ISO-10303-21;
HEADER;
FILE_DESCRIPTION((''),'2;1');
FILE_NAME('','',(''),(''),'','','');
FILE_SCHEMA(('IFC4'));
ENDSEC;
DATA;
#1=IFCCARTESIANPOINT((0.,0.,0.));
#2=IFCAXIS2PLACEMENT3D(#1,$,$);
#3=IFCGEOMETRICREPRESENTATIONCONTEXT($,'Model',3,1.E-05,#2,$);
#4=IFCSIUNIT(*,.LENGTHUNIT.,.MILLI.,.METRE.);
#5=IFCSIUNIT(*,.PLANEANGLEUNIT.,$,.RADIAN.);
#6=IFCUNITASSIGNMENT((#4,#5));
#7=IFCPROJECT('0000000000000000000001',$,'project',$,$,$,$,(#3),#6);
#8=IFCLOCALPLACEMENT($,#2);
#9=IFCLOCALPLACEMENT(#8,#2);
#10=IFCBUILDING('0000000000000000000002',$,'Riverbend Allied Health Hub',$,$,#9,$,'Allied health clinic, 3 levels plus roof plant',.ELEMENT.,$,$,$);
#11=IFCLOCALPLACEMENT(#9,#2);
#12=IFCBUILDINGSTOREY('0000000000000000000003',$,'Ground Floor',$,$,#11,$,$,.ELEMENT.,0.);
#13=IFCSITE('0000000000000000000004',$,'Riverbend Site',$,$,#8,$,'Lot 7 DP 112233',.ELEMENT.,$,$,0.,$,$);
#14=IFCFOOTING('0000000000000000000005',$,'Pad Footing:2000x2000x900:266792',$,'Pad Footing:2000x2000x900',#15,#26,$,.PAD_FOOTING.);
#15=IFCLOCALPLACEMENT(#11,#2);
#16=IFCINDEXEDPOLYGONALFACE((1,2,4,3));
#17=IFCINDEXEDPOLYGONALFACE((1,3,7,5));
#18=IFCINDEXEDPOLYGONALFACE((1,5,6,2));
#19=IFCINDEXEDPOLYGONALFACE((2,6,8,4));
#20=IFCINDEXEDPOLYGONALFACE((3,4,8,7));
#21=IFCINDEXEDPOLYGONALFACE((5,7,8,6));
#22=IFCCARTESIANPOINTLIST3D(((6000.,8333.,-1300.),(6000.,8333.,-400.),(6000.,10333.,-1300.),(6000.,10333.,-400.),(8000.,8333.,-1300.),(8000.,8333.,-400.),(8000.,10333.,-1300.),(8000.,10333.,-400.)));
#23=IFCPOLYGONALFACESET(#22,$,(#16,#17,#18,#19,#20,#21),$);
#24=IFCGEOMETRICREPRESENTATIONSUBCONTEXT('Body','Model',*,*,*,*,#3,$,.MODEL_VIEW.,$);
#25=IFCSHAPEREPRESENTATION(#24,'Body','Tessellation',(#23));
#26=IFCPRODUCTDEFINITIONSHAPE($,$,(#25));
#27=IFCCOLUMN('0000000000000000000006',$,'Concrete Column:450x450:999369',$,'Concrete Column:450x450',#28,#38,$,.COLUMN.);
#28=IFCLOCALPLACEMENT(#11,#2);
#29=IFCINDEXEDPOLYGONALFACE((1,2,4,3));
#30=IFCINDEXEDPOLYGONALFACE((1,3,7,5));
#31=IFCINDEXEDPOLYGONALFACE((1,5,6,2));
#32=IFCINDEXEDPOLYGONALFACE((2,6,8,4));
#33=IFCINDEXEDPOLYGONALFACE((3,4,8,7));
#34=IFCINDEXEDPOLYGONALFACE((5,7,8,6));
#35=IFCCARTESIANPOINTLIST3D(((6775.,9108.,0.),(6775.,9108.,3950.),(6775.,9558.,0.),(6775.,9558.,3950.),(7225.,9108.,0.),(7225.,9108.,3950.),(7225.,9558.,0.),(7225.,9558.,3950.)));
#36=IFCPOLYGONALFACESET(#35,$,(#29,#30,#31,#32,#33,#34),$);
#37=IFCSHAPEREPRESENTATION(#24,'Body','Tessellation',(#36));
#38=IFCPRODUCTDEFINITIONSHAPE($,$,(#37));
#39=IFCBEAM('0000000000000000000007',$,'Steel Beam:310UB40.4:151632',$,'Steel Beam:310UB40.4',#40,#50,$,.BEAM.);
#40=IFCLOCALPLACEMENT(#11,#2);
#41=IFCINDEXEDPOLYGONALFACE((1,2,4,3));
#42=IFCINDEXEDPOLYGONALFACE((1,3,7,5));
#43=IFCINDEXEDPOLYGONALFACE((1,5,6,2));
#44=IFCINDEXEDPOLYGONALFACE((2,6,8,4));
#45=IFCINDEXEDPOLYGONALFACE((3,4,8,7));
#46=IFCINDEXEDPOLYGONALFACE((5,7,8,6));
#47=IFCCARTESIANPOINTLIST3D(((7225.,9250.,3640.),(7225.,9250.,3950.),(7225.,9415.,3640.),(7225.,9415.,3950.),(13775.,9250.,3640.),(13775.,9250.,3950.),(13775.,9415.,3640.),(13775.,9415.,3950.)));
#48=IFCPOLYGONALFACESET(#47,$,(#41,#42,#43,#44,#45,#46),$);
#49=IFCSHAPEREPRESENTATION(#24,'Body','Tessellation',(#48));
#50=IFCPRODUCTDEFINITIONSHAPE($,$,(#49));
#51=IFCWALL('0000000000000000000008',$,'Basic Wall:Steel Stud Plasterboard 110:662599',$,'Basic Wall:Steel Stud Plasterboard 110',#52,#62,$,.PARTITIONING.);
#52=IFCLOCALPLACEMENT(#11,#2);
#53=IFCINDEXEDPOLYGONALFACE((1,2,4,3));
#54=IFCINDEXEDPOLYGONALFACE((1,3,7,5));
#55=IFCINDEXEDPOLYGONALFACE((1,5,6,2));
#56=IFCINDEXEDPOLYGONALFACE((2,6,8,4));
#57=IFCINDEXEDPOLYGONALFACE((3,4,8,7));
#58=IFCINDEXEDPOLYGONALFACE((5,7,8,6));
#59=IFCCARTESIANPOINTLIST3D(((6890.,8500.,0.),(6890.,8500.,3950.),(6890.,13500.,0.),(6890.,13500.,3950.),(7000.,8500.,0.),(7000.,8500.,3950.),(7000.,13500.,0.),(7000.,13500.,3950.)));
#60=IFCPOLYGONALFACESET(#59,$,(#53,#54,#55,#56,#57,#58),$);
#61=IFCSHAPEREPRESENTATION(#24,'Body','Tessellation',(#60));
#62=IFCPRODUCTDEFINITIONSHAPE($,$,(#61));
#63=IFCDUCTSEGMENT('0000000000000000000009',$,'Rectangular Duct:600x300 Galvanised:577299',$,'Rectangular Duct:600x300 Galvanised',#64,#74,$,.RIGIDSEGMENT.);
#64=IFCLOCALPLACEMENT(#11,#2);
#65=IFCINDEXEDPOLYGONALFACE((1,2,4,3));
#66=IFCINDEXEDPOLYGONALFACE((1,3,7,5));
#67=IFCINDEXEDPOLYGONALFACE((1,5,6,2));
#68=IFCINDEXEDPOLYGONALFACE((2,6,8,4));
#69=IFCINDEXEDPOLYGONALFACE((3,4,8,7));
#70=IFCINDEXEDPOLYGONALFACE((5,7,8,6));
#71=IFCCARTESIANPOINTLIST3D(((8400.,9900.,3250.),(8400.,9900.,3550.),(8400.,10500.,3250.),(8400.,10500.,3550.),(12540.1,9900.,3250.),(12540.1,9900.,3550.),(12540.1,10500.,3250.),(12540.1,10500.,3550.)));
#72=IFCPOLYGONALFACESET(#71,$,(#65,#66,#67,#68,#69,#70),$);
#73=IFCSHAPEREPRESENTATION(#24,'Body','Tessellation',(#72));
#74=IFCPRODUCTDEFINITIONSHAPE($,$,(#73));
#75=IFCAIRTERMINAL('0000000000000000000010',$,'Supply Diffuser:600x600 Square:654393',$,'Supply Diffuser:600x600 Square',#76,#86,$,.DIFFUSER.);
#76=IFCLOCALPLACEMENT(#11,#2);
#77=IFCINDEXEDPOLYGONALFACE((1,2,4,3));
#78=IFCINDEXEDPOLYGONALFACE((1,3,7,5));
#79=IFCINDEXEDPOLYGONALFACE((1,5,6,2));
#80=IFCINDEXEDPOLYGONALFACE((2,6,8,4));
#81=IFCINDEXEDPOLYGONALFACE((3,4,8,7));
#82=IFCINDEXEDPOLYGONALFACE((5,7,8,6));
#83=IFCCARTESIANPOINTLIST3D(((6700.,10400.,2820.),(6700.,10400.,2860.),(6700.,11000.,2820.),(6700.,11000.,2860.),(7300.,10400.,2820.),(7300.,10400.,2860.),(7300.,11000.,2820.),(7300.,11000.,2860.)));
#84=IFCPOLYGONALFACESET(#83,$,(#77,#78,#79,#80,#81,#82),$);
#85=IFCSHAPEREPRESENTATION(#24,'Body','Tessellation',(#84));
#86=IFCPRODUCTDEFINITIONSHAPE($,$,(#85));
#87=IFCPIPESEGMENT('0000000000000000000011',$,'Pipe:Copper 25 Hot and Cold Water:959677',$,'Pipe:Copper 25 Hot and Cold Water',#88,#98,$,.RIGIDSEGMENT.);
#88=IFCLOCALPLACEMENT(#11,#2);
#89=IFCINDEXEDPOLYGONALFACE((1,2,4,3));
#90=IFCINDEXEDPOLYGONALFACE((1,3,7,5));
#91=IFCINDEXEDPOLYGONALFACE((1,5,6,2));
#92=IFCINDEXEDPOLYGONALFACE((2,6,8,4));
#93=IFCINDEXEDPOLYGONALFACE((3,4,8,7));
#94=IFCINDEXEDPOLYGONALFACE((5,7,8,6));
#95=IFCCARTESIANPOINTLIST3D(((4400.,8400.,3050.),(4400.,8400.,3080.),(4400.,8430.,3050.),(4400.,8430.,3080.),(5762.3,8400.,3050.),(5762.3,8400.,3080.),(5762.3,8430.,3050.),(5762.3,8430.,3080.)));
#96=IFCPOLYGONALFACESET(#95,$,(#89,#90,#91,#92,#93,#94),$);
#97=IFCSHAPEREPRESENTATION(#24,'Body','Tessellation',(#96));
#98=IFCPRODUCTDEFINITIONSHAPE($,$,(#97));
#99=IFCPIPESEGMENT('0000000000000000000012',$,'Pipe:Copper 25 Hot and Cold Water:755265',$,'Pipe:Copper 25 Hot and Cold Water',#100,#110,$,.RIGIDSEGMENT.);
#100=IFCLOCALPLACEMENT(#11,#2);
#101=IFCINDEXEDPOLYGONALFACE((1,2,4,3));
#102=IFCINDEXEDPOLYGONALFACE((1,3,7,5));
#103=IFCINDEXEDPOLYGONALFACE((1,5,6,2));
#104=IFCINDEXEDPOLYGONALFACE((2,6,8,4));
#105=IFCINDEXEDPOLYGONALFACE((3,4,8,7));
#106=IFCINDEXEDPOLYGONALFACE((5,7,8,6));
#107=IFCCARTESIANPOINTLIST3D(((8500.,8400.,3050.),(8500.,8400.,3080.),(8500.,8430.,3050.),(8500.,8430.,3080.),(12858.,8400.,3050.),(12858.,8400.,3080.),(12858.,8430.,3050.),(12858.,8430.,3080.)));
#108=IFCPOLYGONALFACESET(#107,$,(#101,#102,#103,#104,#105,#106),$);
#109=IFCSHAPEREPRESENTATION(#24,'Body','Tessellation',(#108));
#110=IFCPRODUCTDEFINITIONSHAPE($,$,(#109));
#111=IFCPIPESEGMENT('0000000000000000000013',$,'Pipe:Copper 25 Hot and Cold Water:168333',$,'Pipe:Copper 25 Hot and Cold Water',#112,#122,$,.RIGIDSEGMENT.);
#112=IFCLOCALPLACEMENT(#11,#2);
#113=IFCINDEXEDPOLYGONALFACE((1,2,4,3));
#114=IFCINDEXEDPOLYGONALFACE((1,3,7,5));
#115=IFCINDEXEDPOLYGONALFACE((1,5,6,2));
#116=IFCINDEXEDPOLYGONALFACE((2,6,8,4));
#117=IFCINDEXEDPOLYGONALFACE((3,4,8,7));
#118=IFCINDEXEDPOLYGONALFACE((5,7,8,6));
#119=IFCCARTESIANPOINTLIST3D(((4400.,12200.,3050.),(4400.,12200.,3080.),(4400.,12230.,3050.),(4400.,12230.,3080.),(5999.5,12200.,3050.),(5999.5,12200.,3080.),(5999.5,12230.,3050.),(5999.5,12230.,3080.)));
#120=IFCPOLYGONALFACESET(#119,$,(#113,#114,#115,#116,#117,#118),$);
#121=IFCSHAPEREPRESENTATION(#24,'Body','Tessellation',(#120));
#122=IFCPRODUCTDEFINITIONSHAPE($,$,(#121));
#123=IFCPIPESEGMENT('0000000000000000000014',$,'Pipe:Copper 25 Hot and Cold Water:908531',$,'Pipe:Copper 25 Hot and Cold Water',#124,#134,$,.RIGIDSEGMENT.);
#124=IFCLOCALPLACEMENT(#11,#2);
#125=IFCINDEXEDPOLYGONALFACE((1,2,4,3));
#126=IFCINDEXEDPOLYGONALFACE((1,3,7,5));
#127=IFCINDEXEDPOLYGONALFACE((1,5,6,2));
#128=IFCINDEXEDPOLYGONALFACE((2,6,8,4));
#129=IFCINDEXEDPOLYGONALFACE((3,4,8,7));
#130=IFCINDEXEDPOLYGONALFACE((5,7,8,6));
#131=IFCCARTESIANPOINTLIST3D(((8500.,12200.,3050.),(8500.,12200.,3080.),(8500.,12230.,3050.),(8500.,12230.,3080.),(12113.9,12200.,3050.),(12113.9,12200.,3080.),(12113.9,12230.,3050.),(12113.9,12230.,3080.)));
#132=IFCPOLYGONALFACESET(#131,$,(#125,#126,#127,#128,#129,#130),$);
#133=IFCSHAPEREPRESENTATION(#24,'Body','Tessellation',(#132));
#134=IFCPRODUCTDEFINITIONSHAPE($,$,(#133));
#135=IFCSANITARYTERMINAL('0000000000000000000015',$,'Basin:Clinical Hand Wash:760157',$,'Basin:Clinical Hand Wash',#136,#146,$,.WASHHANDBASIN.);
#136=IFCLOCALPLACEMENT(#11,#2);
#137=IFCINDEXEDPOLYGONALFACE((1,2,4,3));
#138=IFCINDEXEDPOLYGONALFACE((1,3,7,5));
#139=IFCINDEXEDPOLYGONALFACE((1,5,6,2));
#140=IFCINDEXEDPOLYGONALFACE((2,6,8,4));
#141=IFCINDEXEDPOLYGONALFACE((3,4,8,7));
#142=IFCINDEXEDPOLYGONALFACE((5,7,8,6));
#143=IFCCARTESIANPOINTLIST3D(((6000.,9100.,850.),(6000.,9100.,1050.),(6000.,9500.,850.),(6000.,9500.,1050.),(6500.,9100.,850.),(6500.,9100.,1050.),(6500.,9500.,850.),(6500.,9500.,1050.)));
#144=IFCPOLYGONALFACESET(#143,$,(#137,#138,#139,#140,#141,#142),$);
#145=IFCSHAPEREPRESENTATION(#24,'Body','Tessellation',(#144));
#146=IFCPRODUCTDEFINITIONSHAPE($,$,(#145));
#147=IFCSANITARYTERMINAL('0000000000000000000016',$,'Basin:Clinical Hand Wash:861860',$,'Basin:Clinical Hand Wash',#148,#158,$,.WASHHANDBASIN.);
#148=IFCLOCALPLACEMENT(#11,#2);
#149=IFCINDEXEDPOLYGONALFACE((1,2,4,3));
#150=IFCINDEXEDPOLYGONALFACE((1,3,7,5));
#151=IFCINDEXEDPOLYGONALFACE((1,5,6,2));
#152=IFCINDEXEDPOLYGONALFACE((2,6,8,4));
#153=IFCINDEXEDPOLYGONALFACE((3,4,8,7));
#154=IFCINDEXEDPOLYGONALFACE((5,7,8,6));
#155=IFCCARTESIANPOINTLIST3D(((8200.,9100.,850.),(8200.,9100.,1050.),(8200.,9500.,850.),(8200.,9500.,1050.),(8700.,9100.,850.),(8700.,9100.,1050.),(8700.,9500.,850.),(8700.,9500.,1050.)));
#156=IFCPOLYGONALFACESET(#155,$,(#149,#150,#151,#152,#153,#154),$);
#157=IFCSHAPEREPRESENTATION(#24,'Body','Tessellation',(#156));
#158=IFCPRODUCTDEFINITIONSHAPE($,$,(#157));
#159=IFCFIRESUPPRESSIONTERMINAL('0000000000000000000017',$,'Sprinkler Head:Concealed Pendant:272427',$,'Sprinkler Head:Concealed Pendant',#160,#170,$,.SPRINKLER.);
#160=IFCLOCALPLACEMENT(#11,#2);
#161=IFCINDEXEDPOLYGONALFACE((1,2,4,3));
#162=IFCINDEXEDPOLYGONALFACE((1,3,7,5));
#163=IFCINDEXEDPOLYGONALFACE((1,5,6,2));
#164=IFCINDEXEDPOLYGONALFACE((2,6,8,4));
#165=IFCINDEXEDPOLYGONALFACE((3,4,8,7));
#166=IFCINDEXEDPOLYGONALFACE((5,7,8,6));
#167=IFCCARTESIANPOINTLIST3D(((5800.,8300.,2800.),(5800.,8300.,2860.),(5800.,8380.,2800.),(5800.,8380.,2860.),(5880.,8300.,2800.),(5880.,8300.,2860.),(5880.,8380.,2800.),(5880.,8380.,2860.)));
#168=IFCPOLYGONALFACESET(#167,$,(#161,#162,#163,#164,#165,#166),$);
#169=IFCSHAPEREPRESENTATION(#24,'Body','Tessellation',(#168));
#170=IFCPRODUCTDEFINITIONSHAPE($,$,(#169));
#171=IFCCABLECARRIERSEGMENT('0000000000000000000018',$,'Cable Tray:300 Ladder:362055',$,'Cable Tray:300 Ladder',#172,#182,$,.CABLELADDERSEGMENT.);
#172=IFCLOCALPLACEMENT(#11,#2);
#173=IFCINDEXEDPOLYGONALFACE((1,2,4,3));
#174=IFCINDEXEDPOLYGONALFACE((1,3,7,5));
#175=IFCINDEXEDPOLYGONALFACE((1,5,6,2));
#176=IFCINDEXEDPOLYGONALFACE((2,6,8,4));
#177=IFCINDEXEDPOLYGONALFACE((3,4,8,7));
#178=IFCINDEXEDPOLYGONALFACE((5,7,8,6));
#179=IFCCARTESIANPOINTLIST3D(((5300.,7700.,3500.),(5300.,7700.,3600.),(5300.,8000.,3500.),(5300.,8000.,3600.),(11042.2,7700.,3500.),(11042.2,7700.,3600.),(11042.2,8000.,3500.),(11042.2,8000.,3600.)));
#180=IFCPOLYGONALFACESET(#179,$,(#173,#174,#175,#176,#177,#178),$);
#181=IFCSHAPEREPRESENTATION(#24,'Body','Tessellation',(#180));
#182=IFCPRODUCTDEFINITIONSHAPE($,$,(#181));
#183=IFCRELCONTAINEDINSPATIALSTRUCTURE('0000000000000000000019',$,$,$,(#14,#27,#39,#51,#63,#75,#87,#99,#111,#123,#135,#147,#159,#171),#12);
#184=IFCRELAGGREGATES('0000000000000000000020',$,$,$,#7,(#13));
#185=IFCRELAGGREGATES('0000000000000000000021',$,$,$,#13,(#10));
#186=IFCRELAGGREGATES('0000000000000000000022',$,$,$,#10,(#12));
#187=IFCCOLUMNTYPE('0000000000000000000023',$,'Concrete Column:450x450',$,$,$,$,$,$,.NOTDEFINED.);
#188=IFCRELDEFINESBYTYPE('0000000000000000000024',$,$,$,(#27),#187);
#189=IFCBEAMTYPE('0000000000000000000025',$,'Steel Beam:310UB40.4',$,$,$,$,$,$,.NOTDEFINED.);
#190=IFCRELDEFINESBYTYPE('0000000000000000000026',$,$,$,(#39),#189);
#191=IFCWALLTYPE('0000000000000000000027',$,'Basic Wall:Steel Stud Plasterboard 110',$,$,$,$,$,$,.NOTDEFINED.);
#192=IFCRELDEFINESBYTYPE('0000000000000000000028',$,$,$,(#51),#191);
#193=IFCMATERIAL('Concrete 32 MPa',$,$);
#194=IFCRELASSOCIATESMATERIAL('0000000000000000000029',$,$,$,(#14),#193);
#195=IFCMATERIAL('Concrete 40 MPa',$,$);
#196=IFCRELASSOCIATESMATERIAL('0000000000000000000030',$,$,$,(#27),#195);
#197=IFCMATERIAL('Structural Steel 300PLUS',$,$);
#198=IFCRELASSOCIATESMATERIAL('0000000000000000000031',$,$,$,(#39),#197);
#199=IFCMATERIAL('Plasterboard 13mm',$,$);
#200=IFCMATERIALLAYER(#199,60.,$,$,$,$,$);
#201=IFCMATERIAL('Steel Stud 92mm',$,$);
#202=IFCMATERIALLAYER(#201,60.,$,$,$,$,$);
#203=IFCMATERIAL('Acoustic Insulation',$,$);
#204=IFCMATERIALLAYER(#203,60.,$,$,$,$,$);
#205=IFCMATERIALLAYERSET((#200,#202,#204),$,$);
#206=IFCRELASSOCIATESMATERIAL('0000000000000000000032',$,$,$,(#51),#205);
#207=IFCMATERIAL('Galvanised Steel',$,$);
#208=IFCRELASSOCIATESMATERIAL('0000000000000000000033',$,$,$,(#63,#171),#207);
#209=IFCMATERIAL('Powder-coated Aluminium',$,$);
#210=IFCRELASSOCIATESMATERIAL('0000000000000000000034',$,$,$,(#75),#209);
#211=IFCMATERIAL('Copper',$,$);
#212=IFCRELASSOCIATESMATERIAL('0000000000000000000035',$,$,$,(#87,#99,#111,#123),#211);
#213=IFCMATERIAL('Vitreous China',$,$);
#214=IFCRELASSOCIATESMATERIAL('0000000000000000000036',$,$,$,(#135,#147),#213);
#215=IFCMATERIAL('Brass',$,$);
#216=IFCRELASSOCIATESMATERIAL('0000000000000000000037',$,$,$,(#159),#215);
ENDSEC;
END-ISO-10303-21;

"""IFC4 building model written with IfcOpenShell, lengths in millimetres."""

from ifc_helpers import new_model, si_unit, frame, frame_2d, origin, place, context, subcontext, project, spatial, rectangle, extrude, material, layer, layer_set, layer_usage, type_object, element, save


model = new_model("IFC4")

# Units and contexts
model_context = context("Model", 3, precision=1e-05, world=origin())
body_context = subcontext(model_context, "Body", "Model", "MODEL_VIEW")
ifc_project = project(units=[si_unit("LENGTHUNIT", "METRE", prefix="MILLI"), si_unit("PLANEANGLEUNIT", "RADIAN")], contexts=[model_context])

# Site, building, storey
site_placement = place(None, origin())
site = spatial("IfcSite", under=ifc_project, at=site_placement, Name="Riverbend Site", LongName="Lot 7 DP 112233", CompositionType="ELEMENT", RefElevation=0.0)
building_placement = place(site_placement, origin())
building = spatial("IfcBuilding", under=site, at=building_placement, Name="Riverbend Allied Health Hub", LongName="Allied health clinic, 3 levels plus roof plant", CompositionType="ELEMENT")
storey_placement = place(building_placement, origin())
storey = spatial("IfcBuildingStorey", under=building, at=storey_placement, Name="Ground Floor", CompositionType="ELEMENT", Elevation=0.0)

# Footing
ifc_material_1 = material(Name="Concrete 32 MPa")
footing_placement = place(storey_placement, frame((6000.0, 8333.0, -1300.0)))
element("IfcFooting", 1, at=footing_placement, inside=storey, material=ifc_material_1, Name="Pad Footing:2000x2000x900:266792", ObjectType="Pad Footing:2000x2000x900", PredefinedType="PAD_FOOTING", context=body_context, shape_type="SweptSolid", body=[
    extrude(rectangle(XDim=2000.0, YDim=2000.0, at=frame_2d((1000.0, 1000.0))), origin(), (0.0, 0.0, 1.0), 900.0),
])

# Column
ifc_material_2 = material(Name="Concrete 40 MPa")
column_type = type_object("IfcColumnType", Name="Concrete Column:450x450", PredefinedType="NOTDEFINED")
column_placement = place(storey_placement, frame((6775.0, 9108.0, 0.0)))
element("IfcColumn", 2, at=column_placement, inside=storey, type_object=column_type, material=ifc_material_2, Name="Concrete Column:450x450:999369", ObjectType="Concrete Column:450x450", PredefinedType="COLUMN", context=body_context, shape_type="SweptSolid", body=[
    extrude(rectangle(XDim=450.0, YDim=450.0, at=frame_2d((225.0, 225.0))), origin(), (0.0, 0.0, 1.0), 3950.0),
])

# Beam
ifc_material_3 = material(Name="Structural Steel 300PLUS")
beam_type = type_object("IfcBeamType", Name="Steel Beam:310UB40.4", PredefinedType="NOTDEFINED")
beam_placement = place(storey_placement, frame((7225.0, 9250.0, 3640.0)))
element("IfcBeam", 3, at=beam_placement, inside=storey, type_object=beam_type, material=ifc_material_3, Name="Steel Beam:310UB40.4:151632", ObjectType="Steel Beam:310UB40.4", PredefinedType="BEAM", context=body_context, shape_type="SweptSolid", body=[
    extrude(rectangle(XDim=6550.0, YDim=165.0, at=frame_2d((3275.0, 82.5))), origin(), (0.0, 0.0, 1.0), 310.0),
])

# Wall
ifc_material_4 = material(Name="Plasterboard 13mm")
ifc_layer_1 = layer(ifc_material_4, 60.0)
ifc_material_5 = material(Name="Steel Stud 92mm")
ifc_layer_2 = layer(ifc_material_5, 60.0)
ifc_material_6 = material(Name="Acoustic Insulation")
ifc_layer_3 = layer(ifc_material_6, 60.0)
ifc_layer_set = layer_set([ifc_layer_1, ifc_layer_2, ifc_layer_3])
ifc_layer_usage = layer_usage(ifc_layer_set, "AXIS2", "POSITIVE", 0.0)
wall_type = type_object("IfcWallType", Name="Basic Wall:Steel Stud Plasterboard 110", PredefinedType="NOTDEFINED")
wall_placement = place(storey_placement, frame((7000.0, 8500.0, 0.0), z_axis=(0.0, 0.0, 1.0), x_axis=(0.0, 1.0, 0.0)))
element("IfcWall", 4, at=wall_placement, inside=storey, type_object=wall_type, material=ifc_layer_usage, Name="Basic Wall:Steel Stud Plasterboard 110:662599", ObjectType="Basic Wall:Steel Stud Plasterboard 110", PredefinedType="PARTITIONING", context=body_context, shape_type="SweptSolid", body=[
    extrude(rectangle(XDim=5000.0, YDim=110.0, at=frame_2d((2500.0, 55.0))), origin(), (0.0, 0.0, 1.0), 3950.0),
])

# Duct segment
ifc_material_7 = material(Name="Galvanised Steel")
duct_segment_placement = place(storey_placement, frame((8400.0, 9900.0, 3250.0)))
element("IfcDuctSegment", 5, at=duct_segment_placement, inside=storey, material=ifc_material_7, Name="Rectangular Duct:600x300 Galvanised:577299", ObjectType="Rectangular Duct:600x300 Galvanised", PredefinedType="RIGIDSEGMENT", context=body_context, shape_type="SweptSolid", body=[
    extrude(rectangle(XDim=4140.1, YDim=600.0, at=frame_2d((2070.0, 300.0))), origin(), (0.0, 0.0, 1.0), 300.0),
])

# Air terminal
ifc_material_8 = material(Name="Powder-coated Aluminium")
air_terminal_placement = place(storey_placement, frame((6700.0, 10400.0, 2820.0)))
element("IfcAirTerminal", 6, at=air_terminal_placement, inside=storey, material=ifc_material_8, Name="Supply Diffuser:600x600 Square:654393", ObjectType="Supply Diffuser:600x600 Square", PredefinedType="DIFFUSER", context=body_context, shape_type="SweptSolid", body=[
    extrude(rectangle(XDim=600.0, YDim=600.0, at=frame_2d((300.0, 300.0))), origin(), (0.0, 0.0, 1.0), 40.0),
])

# Pipe segments
ifc_material_9 = material(Name="Copper")
pipe_segment_1_placement = place(storey_placement, frame((4400.0, 8400.0, 3050.0)))
element("IfcPipeSegment", 7, at=pipe_segment_1_placement, inside=storey, material=ifc_material_9, Name="Pipe:Copper 25 Hot and Cold Water:959677", ObjectType="Pipe:Copper 25 Hot and Cold Water", PredefinedType="RIGIDSEGMENT", context=body_context, shape_type="SweptSolid", body=[
    extrude(rectangle(XDim=1362.3, YDim=30.0, at=frame_2d((681.2, 15.0))), origin(), (0.0, 0.0, 1.0), 30.0),
])
pipe_segment_2_placement = place(storey_placement, frame((8500.0, 8400.0, 3050.0)))
element("IfcPipeSegment", 8, at=pipe_segment_2_placement, inside=storey, material=ifc_material_9, Name="Pipe:Copper 25 Hot and Cold Water:755265", ObjectType="Pipe:Copper 25 Hot and Cold Water", PredefinedType="RIGIDSEGMENT", context=body_context, shape_type="SweptSolid", body=[
    extrude(rectangle(XDim=4358.0, YDim=30.0, at=frame_2d((2179.0, 15.0))), origin(), (0.0, 0.0, 1.0), 30.0),
])
pipe_segment_3_placement = place(storey_placement, frame((4400.0, 12200.0, 3050.0)))
element("IfcPipeSegment", 9, at=pipe_segment_3_placement, inside=storey, material=ifc_material_9, Name="Pipe:Copper 25 Hot and Cold Water:168333", ObjectType="Pipe:Copper 25 Hot and Cold Water", PredefinedType="RIGIDSEGMENT", context=body_context, shape_type="SweptSolid", body=[
    extrude(rectangle(XDim=1599.5, YDim=30.0, at=frame_2d((799.8, 15.0))), origin(), (0.0, 0.0, 1.0), 30.0),
])
pipe_segment_4_placement = place(storey_placement, frame((8500.0, 12200.0, 3050.0)))
element("IfcPipeSegment", 10, at=pipe_segment_4_placement, inside=storey, material=ifc_material_9, Name="Pipe:Copper 25 Hot and Cold Water:908531", ObjectType="Pipe:Copper 25 Hot and Cold Water", PredefinedType="RIGIDSEGMENT", context=body_context, shape_type="SweptSolid", body=[
    extrude(rectangle(XDim=3613.9, YDim=30.0, at=frame_2d((1807.0, 15.0))), origin(), (0.0, 0.0, 1.0), 30.0),
])

# Sanitary terminals
ifc_material_10 = material(Name="Vitreous China")
for number, where, name in (
    (11, (6000.0, 9100.0, 850.0), "Basin:Clinical Hand Wash:760157"),
    (12, (8200.0, 9100.0, 850.0), "Basin:Clinical Hand Wash:861860"),
):
    element("IfcSanitaryTerminal", number, at=place(storey_placement, frame(where)), inside=storey, material=ifc_material_10, Name=name, ObjectType="Basin:Clinical Hand Wash", PredefinedType="WASHHANDBASIN", context=body_context, shape_type="SweptSolid", body=[
        extrude(rectangle(XDim=500.0, YDim=400.0, at=frame_2d((250.0, 200.0))), origin(), (0.0, 0.0, 1.0), 200.0),
    ])

# Fire suppression terminal
ifc_material_11 = material(Name="Brass")
fire_suppression_terminal_placement = place(storey_placement, frame((5800.0, 8300.0, 2800.0)))
element("IfcFireSuppressionTerminal", 13, at=fire_suppression_terminal_placement, inside=storey, material=ifc_material_11, Name="Sprinkler Head:Concealed Pendant:272427", ObjectType="Sprinkler Head:Concealed Pendant", PredefinedType="SPRINKLER", context=body_context, shape_type="SweptSolid", body=[
    extrude(rectangle(XDim=80.0, YDim=80.0, at=frame_2d((40.0, 40.0))), origin(), (0.0, 0.0, 1.0), 60.0),
])

# Cable carrier segment
cable_carrier_segment_placement = place(storey_placement, frame((5300.0, 7700.0, 3500.0)))
element("IfcCableCarrierSegment", 14, at=cable_carrier_segment_placement, inside=storey, material=ifc_material_7, Name="Cable Tray:300 Ladder:362055", ObjectType="Cable Tray:300 Ladder", PredefinedType="CABLELADDERSEGMENT", context=body_context, shape_type="SweptSolid", body=[
    extrude(rectangle(XDim=5742.2, YDim=300.0, at=frame_2d((2871.1, 150.0))), origin(), (0.0, 0.0, 1.0), 100.0),
])

save(model, "model.ifc")
